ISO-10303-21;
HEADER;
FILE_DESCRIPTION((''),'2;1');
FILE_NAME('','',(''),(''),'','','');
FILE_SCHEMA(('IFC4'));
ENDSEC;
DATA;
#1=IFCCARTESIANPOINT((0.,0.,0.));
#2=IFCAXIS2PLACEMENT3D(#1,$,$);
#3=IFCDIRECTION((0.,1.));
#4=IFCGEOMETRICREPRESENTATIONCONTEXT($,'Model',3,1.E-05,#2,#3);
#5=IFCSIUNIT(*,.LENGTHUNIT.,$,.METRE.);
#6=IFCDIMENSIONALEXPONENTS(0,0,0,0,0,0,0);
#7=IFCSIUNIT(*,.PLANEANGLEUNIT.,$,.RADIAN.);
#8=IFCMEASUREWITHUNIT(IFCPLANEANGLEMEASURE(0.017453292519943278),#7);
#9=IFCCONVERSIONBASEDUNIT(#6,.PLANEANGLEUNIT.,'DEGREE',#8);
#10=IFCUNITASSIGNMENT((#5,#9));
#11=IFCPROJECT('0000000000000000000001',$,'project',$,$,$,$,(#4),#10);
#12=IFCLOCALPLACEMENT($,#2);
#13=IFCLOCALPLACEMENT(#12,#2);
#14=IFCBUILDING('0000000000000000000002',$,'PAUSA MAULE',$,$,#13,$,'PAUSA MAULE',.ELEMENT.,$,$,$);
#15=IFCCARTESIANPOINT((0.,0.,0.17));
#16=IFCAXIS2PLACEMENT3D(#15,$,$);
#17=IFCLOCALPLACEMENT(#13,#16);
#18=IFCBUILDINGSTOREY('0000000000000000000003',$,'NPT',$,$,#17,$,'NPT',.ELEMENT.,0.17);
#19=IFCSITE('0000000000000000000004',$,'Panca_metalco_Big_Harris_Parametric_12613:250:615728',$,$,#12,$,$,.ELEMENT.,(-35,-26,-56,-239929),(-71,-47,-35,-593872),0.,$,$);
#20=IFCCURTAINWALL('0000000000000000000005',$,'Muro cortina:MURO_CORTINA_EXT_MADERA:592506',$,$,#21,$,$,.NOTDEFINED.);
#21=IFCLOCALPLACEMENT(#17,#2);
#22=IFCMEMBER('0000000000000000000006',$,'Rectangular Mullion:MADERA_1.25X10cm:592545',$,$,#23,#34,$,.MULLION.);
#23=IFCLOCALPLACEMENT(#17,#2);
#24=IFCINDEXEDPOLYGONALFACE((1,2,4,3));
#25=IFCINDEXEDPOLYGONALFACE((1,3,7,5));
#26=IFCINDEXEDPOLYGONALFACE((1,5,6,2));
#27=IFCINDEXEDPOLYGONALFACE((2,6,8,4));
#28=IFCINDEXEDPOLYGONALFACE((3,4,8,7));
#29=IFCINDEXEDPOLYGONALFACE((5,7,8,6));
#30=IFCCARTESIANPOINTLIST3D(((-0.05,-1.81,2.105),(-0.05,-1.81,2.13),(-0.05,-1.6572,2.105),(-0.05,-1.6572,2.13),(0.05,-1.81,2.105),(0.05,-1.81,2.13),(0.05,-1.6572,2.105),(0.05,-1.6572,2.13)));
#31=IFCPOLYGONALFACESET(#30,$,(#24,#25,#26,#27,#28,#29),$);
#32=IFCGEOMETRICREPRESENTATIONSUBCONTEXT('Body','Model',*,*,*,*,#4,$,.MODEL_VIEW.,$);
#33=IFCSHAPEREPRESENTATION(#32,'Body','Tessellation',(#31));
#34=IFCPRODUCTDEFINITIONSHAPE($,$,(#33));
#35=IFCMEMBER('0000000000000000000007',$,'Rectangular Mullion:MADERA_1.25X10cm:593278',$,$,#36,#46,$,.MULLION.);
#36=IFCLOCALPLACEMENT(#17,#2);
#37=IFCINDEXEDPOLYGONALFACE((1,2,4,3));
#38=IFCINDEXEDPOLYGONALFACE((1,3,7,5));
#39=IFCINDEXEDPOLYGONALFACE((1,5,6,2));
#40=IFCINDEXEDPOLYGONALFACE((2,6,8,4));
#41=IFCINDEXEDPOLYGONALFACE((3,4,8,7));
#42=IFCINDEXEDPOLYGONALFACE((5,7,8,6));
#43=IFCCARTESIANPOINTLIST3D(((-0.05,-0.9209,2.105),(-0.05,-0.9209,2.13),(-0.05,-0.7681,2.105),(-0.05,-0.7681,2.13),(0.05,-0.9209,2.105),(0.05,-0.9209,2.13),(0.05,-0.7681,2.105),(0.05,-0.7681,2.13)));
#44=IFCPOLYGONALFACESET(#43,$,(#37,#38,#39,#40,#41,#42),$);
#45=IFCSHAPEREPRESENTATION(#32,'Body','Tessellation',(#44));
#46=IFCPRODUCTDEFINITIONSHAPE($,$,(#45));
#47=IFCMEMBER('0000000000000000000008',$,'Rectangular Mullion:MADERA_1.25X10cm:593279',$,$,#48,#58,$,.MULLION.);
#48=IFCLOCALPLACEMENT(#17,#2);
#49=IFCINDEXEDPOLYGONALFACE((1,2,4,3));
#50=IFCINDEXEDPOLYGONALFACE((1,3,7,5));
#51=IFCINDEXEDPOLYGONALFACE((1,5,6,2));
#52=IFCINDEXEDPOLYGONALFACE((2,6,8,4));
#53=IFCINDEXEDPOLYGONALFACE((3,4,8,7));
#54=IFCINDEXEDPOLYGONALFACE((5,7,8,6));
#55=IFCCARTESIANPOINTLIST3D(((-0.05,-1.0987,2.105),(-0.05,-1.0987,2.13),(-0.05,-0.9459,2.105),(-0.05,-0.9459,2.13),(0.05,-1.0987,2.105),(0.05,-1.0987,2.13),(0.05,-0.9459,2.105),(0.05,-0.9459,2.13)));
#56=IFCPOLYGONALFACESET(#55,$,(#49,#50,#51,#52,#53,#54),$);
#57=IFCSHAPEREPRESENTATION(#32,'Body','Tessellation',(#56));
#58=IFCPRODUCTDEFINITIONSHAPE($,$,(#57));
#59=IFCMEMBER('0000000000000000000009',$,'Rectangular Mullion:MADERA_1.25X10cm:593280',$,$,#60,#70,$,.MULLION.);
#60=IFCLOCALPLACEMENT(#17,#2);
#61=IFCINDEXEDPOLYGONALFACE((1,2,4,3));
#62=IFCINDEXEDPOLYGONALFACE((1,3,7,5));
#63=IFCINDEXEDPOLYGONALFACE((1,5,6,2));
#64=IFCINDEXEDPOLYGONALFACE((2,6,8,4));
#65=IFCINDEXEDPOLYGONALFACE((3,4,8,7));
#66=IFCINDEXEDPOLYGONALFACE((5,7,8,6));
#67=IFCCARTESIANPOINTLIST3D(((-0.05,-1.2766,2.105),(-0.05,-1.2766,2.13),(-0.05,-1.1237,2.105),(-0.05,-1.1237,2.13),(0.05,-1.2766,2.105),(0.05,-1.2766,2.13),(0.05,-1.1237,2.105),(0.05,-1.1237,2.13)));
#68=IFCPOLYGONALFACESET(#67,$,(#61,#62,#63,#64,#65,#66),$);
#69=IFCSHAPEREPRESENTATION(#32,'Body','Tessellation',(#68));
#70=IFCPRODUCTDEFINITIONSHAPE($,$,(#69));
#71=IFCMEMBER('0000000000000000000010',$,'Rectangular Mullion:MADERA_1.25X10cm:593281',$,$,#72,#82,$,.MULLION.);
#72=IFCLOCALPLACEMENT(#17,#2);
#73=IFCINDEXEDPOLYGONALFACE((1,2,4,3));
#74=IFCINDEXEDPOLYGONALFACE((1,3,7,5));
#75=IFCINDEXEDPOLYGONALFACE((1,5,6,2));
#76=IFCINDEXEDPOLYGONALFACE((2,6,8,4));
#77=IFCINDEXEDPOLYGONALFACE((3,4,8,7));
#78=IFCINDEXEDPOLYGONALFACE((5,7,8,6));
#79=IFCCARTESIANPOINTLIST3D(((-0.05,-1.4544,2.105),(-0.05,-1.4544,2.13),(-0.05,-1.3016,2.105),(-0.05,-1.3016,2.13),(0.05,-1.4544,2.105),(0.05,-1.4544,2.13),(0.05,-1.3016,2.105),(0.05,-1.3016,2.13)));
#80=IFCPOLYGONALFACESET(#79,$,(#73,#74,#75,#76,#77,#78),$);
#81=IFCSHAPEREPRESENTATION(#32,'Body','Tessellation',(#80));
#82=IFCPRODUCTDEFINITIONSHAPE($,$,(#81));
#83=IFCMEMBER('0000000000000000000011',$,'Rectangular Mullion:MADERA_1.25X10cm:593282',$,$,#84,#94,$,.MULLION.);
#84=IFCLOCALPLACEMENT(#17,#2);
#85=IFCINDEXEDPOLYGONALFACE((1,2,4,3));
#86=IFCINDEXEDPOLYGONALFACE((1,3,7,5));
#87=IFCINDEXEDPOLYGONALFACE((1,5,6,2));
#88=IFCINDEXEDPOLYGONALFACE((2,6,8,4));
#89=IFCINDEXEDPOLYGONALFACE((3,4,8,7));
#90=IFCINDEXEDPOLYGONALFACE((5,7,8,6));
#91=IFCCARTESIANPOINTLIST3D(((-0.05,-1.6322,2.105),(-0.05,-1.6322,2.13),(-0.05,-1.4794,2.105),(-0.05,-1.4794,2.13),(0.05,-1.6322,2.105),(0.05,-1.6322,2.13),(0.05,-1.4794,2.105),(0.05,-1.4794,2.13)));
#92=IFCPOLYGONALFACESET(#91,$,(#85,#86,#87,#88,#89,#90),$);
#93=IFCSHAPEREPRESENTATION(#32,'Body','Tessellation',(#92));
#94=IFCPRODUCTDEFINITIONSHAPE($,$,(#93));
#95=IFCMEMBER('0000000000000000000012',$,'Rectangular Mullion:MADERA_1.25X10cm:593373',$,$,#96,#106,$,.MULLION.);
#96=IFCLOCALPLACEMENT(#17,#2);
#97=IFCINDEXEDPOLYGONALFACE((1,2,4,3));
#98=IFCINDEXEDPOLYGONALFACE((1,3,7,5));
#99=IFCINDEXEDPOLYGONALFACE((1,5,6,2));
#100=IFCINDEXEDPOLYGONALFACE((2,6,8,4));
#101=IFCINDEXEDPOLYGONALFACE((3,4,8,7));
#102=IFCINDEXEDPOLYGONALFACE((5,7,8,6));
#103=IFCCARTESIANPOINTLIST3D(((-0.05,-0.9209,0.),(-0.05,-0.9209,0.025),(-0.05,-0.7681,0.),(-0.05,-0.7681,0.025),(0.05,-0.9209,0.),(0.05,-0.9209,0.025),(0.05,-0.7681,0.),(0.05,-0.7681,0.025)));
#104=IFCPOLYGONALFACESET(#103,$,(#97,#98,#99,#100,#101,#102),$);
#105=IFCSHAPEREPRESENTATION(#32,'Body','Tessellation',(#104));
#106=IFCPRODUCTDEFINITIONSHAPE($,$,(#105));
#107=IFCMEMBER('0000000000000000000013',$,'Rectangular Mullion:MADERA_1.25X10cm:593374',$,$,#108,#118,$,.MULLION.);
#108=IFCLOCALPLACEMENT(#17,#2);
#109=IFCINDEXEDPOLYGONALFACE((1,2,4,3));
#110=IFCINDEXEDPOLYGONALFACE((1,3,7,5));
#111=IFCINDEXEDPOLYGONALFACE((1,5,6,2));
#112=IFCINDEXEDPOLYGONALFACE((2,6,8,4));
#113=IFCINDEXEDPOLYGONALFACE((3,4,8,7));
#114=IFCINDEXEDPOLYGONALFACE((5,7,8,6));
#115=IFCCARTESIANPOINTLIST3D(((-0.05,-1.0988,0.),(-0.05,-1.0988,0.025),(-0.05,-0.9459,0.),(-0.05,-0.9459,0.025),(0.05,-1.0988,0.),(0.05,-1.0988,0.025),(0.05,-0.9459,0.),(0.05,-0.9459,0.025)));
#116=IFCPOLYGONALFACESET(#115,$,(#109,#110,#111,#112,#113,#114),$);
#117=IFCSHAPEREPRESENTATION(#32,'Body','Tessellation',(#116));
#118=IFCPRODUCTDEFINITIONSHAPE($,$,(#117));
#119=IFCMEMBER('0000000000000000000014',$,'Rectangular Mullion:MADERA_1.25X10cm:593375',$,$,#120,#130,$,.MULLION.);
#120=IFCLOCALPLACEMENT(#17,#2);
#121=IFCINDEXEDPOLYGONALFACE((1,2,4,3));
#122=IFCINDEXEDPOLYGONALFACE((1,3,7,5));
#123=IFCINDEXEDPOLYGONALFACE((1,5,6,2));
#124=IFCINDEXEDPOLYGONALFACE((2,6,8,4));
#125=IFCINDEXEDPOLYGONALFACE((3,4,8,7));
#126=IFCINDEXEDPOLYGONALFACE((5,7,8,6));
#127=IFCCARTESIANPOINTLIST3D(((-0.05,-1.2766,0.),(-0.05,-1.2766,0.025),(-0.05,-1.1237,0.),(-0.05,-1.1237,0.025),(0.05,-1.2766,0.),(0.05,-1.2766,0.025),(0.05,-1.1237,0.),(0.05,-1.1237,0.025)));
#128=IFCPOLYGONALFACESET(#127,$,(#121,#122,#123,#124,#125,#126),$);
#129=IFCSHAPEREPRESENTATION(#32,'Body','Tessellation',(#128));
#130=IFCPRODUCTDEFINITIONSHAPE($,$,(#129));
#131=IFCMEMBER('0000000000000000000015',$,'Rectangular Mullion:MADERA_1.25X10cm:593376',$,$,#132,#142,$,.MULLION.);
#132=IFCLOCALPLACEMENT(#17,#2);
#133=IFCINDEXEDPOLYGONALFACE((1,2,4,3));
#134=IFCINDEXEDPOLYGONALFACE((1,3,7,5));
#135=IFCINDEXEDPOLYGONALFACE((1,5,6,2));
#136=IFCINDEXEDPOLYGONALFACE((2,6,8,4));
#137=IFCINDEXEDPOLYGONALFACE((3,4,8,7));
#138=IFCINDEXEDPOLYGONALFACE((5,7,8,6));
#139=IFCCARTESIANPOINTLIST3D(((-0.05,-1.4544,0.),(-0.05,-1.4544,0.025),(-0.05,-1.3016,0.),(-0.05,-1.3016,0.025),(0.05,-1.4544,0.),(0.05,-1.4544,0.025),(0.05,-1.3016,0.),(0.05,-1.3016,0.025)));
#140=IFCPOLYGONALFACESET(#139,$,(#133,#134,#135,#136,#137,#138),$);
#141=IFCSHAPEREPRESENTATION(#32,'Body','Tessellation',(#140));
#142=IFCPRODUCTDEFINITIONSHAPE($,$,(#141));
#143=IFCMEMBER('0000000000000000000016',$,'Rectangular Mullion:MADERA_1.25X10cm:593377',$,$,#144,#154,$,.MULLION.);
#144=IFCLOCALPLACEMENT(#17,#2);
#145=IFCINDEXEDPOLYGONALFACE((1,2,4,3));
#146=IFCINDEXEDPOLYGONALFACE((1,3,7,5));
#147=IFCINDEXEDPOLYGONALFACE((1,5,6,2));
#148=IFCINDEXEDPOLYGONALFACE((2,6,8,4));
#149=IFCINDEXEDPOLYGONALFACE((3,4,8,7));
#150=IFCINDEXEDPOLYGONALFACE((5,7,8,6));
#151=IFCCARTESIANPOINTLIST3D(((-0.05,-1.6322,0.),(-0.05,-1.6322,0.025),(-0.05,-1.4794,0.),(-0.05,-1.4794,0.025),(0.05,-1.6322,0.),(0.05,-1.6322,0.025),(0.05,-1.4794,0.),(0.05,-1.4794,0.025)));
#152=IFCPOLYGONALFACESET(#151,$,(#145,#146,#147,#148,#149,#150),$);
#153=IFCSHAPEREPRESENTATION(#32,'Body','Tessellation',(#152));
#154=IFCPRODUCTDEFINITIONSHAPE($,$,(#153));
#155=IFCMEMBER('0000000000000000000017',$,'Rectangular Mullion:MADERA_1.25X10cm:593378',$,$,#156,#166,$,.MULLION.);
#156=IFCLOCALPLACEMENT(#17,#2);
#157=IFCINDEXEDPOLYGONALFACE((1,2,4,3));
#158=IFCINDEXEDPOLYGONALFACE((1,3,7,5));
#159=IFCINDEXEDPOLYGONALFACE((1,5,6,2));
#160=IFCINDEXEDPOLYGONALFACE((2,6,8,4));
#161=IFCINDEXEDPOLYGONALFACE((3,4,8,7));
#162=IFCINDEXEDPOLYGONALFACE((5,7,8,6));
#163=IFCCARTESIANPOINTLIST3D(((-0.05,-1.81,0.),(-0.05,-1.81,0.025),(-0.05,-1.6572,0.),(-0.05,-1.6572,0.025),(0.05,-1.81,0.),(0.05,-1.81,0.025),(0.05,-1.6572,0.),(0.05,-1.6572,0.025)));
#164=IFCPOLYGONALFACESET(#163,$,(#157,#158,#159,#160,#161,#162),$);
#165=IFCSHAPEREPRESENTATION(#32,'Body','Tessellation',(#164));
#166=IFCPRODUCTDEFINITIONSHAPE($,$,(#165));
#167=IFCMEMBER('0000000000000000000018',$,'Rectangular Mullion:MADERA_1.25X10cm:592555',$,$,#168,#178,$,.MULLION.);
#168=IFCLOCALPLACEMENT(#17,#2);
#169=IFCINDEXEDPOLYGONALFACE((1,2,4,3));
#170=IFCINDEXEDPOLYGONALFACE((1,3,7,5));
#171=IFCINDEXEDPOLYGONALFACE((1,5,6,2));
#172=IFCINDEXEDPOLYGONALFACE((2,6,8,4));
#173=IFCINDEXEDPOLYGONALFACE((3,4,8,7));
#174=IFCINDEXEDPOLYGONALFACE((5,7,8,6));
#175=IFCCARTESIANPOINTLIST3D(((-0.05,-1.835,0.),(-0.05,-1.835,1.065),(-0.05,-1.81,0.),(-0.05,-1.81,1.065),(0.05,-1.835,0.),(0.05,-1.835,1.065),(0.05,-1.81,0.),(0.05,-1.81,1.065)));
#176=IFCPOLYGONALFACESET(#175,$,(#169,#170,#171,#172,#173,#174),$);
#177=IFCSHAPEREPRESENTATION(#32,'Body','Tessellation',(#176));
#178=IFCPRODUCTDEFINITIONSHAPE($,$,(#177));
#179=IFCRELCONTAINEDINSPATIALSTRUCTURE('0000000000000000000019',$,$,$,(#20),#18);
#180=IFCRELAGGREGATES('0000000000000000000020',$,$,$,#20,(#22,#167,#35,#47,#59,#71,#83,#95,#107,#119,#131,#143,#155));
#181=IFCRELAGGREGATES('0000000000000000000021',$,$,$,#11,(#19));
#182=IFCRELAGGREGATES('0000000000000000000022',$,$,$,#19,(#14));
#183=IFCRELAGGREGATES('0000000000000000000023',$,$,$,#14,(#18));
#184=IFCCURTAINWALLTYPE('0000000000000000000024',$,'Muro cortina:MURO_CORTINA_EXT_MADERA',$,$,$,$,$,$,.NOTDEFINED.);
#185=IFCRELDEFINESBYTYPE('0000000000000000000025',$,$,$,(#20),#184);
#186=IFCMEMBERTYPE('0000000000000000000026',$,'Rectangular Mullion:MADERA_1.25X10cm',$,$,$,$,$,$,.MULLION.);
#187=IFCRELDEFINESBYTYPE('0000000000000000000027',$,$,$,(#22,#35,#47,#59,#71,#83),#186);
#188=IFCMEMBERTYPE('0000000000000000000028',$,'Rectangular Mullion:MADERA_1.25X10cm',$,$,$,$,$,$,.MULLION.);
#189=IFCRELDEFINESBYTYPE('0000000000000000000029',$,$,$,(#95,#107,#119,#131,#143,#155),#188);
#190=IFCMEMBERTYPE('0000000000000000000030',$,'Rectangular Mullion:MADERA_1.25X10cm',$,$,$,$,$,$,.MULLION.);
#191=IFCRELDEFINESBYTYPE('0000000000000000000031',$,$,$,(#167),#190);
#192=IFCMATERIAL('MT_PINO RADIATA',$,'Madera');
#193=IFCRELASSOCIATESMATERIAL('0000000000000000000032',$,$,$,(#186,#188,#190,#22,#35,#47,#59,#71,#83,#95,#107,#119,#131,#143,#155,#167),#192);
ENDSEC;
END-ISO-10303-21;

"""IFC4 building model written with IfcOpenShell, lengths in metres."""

from ifc_helpers import new_model, entity, si_unit, converted_unit, direction, frame, frame_2d, origin, origin_2d_with_axis, place, context, subcontext, project, spatial, rectangle, extrude, source, transform, mapped, material, material_profile, profile_set, profile_usage, type_object, type_shapes, element, aggregate, save


model = new_model("IFC4")

# Units and contexts
model_context = context("Model", 3, precision=1e-05, world=origin(), true_north=direction((0.0, 1.0)))
body_context = subcontext(model_context, "Body", "Model", "MODEL_VIEW")
ifc_project = project(units=[si_unit("LENGTHUNIT", "METRE"), converted_unit("PLANEANGLEUNIT", "DEGREE", entity("IfcPlaneAngleMeasure", 0.017453292519943278), si_unit("PLANEANGLEUNIT", "RADIAN"), dimensions=[0, 0, 0, 0, 0, 0, 0])], contexts=[model_context])

# Site, building, storey
site_placement = place(None, origin())
site = spatial("IfcSite", under=ifc_project, at=site_placement, Name="Panca_metalco_Big_Harris_Parametric_12613:250:615728", CompositionType="ELEMENT", RefLatitude=(-35, -26, -56, -239929), RefLongitude=(-71, -47, -35, -593872), RefElevation=0.0)
building_placement = place(site_placement, origin())
building = spatial("IfcBuilding", under=site, at=building_placement, Name="PAUSA MAULE", LongName="PAUSA MAULE", CompositionType="ELEMENT")
storey_placement = place(building_placement, frame((0.0, 0.0, 0.17)))
storey = spatial("IfcBuildingStorey", under=building, at=storey_placement, Name="NPT", LongName="NPT", CompositionType="ELEMENT", Elevation=0.17)

# Curtain wall, members
curtain_wall_type = type_object("IfcCurtainWallType", Name="Muro cortina:MURO_CORTINA_EXT_MADERA", PredefinedType="NOTDEFINED")
curtain_wall_placement = place(storey_placement, frame((0.0, 0.0, -0.17)))
curtain_wall = element("IfcCurtainWall", 1, at=curtain_wall_placement, inside=storey, type_object=curtain_wall_type, Name="Muro cortina:MURO_CORTINA_EXT_MADERA:592506", PredefinedType="NOTDEFINED")
ifc_material = material(Name="MT_PINO RADIATA", Category="Madera")
ifc_material_profile = material_profile(ifc_material, rectangle(XDim=0.025, YDim=0.1, at=frame_2d((0.0, 0.0), x_axis=(1.0, 0.0))), Name="MADERA_1.25X10cm")
ifc_profile_set = profile_set([ifc_material_profile], Name="MADERA_1.25X10cm")
ifc_profile_usage = profile_usage(ifc_profile_set)
member_type_1 = type_object("IfcMemberType", Name="Rectangular Mullion:MADERA_1.25X10cm", PredefinedType="MULLION", material=ifc_profile_set)
shared_shape_1 = source(origin(), body_context, "Body", "SweptSolid", [
    extrude(rectangle(XDim=0.025, YDim=0.1, at=frame_2d((0.0, 0.0), x_axis=(1.0, 0.0))), frame((-0.0125, 0.0, -0.1528), z_axis=(0.0, 0.0, 1.0), x_axis=(-1.0, 0.0, 0.0)), (0.0, 0.0, 1.0), 0.1528),
])
type_shapes(member_type_1, [shared_shape_1])
member_1_placement = place(curtain_wall_placement, frame((0.0, -1.81, 2.3), z_axis=(0.0, -1.0, 0.0), x_axis=(0.0, 0.0, 1.0)))
member_1 = element("IfcMember", 2, at=member_1_placement, type_object=member_type_1, material=ifc_profile_usage, Name="Rectangular Mullion:MADERA_1.25X10cm:592545", PredefinedType="MULLION", context=body_context, shape_type="MappedRepresentation", body=[
    mapped(shared_shape_1, transform((0.0, 0.0, 0.0), scale=1.0)),
])
member_2_placement = place(curtain_wall_placement, frame((0.0, -0.9209, 2.3), z_axis=(0.0, -1.0, 0.0), x_axis=(0.0, 0.0, 1.0)))
member_2 = element("IfcMember", 3, at=member_2_placement, type_object=member_type_1, material=ifc_profile_usage, Name="Rectangular Mullion:MADERA_1.25X10cm:593278", PredefinedType="MULLION", context=body_context, shape_type="MappedRepresentation", body=[
    mapped(shared_shape_1, transform((0.0, 0.0, 0.0), scale=1.0)),
])
member_3_placement = place(curtain_wall_placement, frame((0.0, -1.0987, 2.3), z_axis=(0.0, -1.0, 0.0), x_axis=(0.0, 0.0, 1.0)))
member_3 = element("IfcMember", 4, at=member_3_placement, type_object=member_type_1, material=ifc_profile_usage, Name="Rectangular Mullion:MADERA_1.25X10cm:593279", PredefinedType="MULLION", context=body_context, shape_type="MappedRepresentation", body=[
    mapped(shared_shape_1, transform((0.0, 0.0, 0.0), scale=1.0)),
])
member_4_placement = place(curtain_wall_placement, frame((0.0, -1.2766, 2.3), z_axis=(0.0, -1.0, 0.0), x_axis=(0.0, 0.0, 1.0)))
member_4 = element("IfcMember", 5, at=member_4_placement, type_object=member_type_1, material=ifc_profile_usage, Name="Rectangular Mullion:MADERA_1.25X10cm:593280", PredefinedType="MULLION", context=body_context, shape_type="MappedRepresentation", body=[
    mapped(shared_shape_1, transform((0.0, 0.0, 0.0), scale=1.0)),
])
member_5_placement = place(curtain_wall_placement, frame((0.0, -1.4544, 2.3), z_axis=(0.0, -1.0, 0.0), x_axis=(0.0, 0.0, 1.0)))
member_5 = element("IfcMember", 6, at=member_5_placement, type_object=member_type_1, material=ifc_profile_usage, Name="Rectangular Mullion:MADERA_1.25X10cm:593281", PredefinedType="MULLION", context=body_context, shape_type="MappedRepresentation", body=[
    mapped(shared_shape_1, transform((0.0, 0.0, 0.0), scale=1.0)),
])
member_6_placement = place(curtain_wall_placement, frame((0.0, -1.6322, 2.3), z_axis=(0.0, -1.0, 0.0), x_axis=(0.0, 0.0, 1.0)))
member_6 = element("IfcMember", 7, at=member_6_placement, type_object=member_type_1, material=ifc_profile_usage, Name="Rectangular Mullion:MADERA_1.25X10cm:593282", PredefinedType="MULLION", context=body_context, shape_type="MappedRepresentation", body=[
    mapped(shared_shape_1, transform((0.0, 0.0, 0.0), scale=1.0)),
])
member_type_2 = type_object("IfcMemberType", Name="Rectangular Mullion:MADERA_1.25X10cm", PredefinedType="MULLION", material=ifc_profile_set)
shared_shape_2 = source(origin(), body_context, "Body", "SweptSolid", [
    extrude(rectangle(XDim=0.025, YDim=0.1, at=frame_2d((0.0, 0.0), x_axis=(1.0, 0.0))), frame((-0.0125, 0.0, -0.1528), z_axis=(0.0, 0.0, 1.0), x_axis=(-1.0, 0.0, 0.0)), (0.0, 0.0, 1.0), 0.1528),
])
type_shapes(member_type_2, [shared_shape_2])
member_7_placement = place(curtain_wall_placement, frame((0.0, -0.7681, 0.17), z_axis=(0.0, 1.0, 0.0), x_axis=(0.0, 0.0, -1.0)))
member_7 = element("IfcMember", 8, at=member_7_placement, type_object=member_type_2, material=ifc_profile_usage, Name="Rectangular Mullion:MADERA_1.25X10cm:593373", PredefinedType="MULLION", context=body_context, shape_type="MappedRepresentation", body=[
    mapped(shared_shape_2, transform((0.0, 0.0, 0.0), scale=1.0)),
])
member_8_placement = place(curtain_wall_placement, frame((0.0, -0.9459, 0.17), z_axis=(0.0, 1.0, 0.0), x_axis=(0.0, 0.0, -1.0)))
member_8 = element("IfcMember", 9, at=member_8_placement, type_object=member_type_2, material=ifc_profile_usage, Name="Rectangular Mullion:MADERA_1.25X10cm:593374", PredefinedType="MULLION", context=body_context, shape_type="MappedRepresentation", body=[
    mapped(shared_shape_2, transform((0.0, 0.0, 0.0), scale=1.0)),
])
member_9_placement = place(curtain_wall_placement, frame((0.0, -1.1237, 0.17), z_axis=(0.0, 1.0, 0.0), x_axis=(0.0, 0.0, -1.0)))
member_9 = element("IfcMember", 10, at=member_9_placement, type_object=member_type_2, material=ifc_profile_usage, Name="Rectangular Mullion:MADERA_1.25X10cm:593375", PredefinedType="MULLION", context=body_context, shape_type="MappedRepresentation", body=[
    mapped(shared_shape_2, transform((0.0, 0.0, 0.0), scale=1.0)),
])
member_10_placement = place(curtain_wall_placement, frame((0.0, -1.3016, 0.17), z_axis=(0.0, 1.0, 0.0), x_axis=(0.0, 0.0, -1.0)))
member_10 = element("IfcMember", 11, at=member_10_placement, type_object=member_type_2, material=ifc_profile_usage, Name="Rectangular Mullion:MADERA_1.25X10cm:593376", PredefinedType="MULLION", context=body_context, shape_type="MappedRepresentation", body=[
    mapped(shared_shape_2, transform((0.0, 0.0, 0.0), scale=1.0)),
])
member_11_placement = place(curtain_wall_placement, frame((0.0, -1.4794, 0.17), z_axis=(0.0, 1.0, 0.0), x_axis=(0.0, 0.0, -1.0)))
member_11 = element("IfcMember", 12, at=member_11_placement, type_object=member_type_2, material=ifc_profile_usage, Name="Rectangular Mullion:MADERA_1.25X10cm:593377", PredefinedType="MULLION", context=body_context, shape_type="MappedRepresentation", body=[
    mapped(shared_shape_2, transform((0.0, 0.0, 0.0), scale=1.0)),
])
member_12_placement = place(curtain_wall_placement, frame((0.0, -1.6572, 0.17), z_axis=(0.0, 1.0, 0.0), x_axis=(0.0, 0.0, -1.0)))
member_12 = element("IfcMember", 13, at=member_12_placement, type_object=member_type_2, material=ifc_profile_usage, Name="Rectangular Mullion:MADERA_1.25X10cm:593378", PredefinedType="MULLION", context=body_context, shape_type="MappedRepresentation", body=[
    mapped(shared_shape_2, transform((0.0, 0.0, 0.0), scale=1.0)),
])
member_type_3 = type_object("IfcMemberType", Name="Rectangular Mullion:MADERA_1.25X10cm", PredefinedType="MULLION", material=ifc_profile_set)
shared_shape_3 = source(origin(), body_context, "Body", "SweptSolid", [
    extrude(rectangle(XDim=0.025, YDim=0.1, at=origin_2d_with_axis()), frame((-0.0125, 0.0, -1.065), z_axis=(0.0, 0.0, 1.0), x_axis=(-1.0, 0.0, 0.0)), (0.0, 0.0, 1.0), 1.065),
])
type_shapes(member_type_3, [shared_shape_3])
member_13_placement = place(curtain_wall_placement, frame((0.0, -1.835, 0.17), z_axis=(0.0, 0.0, -1.0), x_axis=(0.0, -1.0, 0.0)))
member_13 = element("IfcMember", 14, at=member_13_placement, type_object=member_type_3, material=ifc_profile_usage, Name="Rectangular Mullion:MADERA_1.25X10cm:592555", PredefinedType="MULLION", context=body_context, shape_type="MappedRepresentation", body=[
    mapped(shared_shape_3, transform((0.0, 0.0, 0.0), scale=1.0)),
])
aggregate(curtain_wall, [member_1, member_13, member_2, member_3, member_4, member_5, member_6, member_7, member_8, member_9, member_10, member_11, member_12])

save(model, "model.ifc")
